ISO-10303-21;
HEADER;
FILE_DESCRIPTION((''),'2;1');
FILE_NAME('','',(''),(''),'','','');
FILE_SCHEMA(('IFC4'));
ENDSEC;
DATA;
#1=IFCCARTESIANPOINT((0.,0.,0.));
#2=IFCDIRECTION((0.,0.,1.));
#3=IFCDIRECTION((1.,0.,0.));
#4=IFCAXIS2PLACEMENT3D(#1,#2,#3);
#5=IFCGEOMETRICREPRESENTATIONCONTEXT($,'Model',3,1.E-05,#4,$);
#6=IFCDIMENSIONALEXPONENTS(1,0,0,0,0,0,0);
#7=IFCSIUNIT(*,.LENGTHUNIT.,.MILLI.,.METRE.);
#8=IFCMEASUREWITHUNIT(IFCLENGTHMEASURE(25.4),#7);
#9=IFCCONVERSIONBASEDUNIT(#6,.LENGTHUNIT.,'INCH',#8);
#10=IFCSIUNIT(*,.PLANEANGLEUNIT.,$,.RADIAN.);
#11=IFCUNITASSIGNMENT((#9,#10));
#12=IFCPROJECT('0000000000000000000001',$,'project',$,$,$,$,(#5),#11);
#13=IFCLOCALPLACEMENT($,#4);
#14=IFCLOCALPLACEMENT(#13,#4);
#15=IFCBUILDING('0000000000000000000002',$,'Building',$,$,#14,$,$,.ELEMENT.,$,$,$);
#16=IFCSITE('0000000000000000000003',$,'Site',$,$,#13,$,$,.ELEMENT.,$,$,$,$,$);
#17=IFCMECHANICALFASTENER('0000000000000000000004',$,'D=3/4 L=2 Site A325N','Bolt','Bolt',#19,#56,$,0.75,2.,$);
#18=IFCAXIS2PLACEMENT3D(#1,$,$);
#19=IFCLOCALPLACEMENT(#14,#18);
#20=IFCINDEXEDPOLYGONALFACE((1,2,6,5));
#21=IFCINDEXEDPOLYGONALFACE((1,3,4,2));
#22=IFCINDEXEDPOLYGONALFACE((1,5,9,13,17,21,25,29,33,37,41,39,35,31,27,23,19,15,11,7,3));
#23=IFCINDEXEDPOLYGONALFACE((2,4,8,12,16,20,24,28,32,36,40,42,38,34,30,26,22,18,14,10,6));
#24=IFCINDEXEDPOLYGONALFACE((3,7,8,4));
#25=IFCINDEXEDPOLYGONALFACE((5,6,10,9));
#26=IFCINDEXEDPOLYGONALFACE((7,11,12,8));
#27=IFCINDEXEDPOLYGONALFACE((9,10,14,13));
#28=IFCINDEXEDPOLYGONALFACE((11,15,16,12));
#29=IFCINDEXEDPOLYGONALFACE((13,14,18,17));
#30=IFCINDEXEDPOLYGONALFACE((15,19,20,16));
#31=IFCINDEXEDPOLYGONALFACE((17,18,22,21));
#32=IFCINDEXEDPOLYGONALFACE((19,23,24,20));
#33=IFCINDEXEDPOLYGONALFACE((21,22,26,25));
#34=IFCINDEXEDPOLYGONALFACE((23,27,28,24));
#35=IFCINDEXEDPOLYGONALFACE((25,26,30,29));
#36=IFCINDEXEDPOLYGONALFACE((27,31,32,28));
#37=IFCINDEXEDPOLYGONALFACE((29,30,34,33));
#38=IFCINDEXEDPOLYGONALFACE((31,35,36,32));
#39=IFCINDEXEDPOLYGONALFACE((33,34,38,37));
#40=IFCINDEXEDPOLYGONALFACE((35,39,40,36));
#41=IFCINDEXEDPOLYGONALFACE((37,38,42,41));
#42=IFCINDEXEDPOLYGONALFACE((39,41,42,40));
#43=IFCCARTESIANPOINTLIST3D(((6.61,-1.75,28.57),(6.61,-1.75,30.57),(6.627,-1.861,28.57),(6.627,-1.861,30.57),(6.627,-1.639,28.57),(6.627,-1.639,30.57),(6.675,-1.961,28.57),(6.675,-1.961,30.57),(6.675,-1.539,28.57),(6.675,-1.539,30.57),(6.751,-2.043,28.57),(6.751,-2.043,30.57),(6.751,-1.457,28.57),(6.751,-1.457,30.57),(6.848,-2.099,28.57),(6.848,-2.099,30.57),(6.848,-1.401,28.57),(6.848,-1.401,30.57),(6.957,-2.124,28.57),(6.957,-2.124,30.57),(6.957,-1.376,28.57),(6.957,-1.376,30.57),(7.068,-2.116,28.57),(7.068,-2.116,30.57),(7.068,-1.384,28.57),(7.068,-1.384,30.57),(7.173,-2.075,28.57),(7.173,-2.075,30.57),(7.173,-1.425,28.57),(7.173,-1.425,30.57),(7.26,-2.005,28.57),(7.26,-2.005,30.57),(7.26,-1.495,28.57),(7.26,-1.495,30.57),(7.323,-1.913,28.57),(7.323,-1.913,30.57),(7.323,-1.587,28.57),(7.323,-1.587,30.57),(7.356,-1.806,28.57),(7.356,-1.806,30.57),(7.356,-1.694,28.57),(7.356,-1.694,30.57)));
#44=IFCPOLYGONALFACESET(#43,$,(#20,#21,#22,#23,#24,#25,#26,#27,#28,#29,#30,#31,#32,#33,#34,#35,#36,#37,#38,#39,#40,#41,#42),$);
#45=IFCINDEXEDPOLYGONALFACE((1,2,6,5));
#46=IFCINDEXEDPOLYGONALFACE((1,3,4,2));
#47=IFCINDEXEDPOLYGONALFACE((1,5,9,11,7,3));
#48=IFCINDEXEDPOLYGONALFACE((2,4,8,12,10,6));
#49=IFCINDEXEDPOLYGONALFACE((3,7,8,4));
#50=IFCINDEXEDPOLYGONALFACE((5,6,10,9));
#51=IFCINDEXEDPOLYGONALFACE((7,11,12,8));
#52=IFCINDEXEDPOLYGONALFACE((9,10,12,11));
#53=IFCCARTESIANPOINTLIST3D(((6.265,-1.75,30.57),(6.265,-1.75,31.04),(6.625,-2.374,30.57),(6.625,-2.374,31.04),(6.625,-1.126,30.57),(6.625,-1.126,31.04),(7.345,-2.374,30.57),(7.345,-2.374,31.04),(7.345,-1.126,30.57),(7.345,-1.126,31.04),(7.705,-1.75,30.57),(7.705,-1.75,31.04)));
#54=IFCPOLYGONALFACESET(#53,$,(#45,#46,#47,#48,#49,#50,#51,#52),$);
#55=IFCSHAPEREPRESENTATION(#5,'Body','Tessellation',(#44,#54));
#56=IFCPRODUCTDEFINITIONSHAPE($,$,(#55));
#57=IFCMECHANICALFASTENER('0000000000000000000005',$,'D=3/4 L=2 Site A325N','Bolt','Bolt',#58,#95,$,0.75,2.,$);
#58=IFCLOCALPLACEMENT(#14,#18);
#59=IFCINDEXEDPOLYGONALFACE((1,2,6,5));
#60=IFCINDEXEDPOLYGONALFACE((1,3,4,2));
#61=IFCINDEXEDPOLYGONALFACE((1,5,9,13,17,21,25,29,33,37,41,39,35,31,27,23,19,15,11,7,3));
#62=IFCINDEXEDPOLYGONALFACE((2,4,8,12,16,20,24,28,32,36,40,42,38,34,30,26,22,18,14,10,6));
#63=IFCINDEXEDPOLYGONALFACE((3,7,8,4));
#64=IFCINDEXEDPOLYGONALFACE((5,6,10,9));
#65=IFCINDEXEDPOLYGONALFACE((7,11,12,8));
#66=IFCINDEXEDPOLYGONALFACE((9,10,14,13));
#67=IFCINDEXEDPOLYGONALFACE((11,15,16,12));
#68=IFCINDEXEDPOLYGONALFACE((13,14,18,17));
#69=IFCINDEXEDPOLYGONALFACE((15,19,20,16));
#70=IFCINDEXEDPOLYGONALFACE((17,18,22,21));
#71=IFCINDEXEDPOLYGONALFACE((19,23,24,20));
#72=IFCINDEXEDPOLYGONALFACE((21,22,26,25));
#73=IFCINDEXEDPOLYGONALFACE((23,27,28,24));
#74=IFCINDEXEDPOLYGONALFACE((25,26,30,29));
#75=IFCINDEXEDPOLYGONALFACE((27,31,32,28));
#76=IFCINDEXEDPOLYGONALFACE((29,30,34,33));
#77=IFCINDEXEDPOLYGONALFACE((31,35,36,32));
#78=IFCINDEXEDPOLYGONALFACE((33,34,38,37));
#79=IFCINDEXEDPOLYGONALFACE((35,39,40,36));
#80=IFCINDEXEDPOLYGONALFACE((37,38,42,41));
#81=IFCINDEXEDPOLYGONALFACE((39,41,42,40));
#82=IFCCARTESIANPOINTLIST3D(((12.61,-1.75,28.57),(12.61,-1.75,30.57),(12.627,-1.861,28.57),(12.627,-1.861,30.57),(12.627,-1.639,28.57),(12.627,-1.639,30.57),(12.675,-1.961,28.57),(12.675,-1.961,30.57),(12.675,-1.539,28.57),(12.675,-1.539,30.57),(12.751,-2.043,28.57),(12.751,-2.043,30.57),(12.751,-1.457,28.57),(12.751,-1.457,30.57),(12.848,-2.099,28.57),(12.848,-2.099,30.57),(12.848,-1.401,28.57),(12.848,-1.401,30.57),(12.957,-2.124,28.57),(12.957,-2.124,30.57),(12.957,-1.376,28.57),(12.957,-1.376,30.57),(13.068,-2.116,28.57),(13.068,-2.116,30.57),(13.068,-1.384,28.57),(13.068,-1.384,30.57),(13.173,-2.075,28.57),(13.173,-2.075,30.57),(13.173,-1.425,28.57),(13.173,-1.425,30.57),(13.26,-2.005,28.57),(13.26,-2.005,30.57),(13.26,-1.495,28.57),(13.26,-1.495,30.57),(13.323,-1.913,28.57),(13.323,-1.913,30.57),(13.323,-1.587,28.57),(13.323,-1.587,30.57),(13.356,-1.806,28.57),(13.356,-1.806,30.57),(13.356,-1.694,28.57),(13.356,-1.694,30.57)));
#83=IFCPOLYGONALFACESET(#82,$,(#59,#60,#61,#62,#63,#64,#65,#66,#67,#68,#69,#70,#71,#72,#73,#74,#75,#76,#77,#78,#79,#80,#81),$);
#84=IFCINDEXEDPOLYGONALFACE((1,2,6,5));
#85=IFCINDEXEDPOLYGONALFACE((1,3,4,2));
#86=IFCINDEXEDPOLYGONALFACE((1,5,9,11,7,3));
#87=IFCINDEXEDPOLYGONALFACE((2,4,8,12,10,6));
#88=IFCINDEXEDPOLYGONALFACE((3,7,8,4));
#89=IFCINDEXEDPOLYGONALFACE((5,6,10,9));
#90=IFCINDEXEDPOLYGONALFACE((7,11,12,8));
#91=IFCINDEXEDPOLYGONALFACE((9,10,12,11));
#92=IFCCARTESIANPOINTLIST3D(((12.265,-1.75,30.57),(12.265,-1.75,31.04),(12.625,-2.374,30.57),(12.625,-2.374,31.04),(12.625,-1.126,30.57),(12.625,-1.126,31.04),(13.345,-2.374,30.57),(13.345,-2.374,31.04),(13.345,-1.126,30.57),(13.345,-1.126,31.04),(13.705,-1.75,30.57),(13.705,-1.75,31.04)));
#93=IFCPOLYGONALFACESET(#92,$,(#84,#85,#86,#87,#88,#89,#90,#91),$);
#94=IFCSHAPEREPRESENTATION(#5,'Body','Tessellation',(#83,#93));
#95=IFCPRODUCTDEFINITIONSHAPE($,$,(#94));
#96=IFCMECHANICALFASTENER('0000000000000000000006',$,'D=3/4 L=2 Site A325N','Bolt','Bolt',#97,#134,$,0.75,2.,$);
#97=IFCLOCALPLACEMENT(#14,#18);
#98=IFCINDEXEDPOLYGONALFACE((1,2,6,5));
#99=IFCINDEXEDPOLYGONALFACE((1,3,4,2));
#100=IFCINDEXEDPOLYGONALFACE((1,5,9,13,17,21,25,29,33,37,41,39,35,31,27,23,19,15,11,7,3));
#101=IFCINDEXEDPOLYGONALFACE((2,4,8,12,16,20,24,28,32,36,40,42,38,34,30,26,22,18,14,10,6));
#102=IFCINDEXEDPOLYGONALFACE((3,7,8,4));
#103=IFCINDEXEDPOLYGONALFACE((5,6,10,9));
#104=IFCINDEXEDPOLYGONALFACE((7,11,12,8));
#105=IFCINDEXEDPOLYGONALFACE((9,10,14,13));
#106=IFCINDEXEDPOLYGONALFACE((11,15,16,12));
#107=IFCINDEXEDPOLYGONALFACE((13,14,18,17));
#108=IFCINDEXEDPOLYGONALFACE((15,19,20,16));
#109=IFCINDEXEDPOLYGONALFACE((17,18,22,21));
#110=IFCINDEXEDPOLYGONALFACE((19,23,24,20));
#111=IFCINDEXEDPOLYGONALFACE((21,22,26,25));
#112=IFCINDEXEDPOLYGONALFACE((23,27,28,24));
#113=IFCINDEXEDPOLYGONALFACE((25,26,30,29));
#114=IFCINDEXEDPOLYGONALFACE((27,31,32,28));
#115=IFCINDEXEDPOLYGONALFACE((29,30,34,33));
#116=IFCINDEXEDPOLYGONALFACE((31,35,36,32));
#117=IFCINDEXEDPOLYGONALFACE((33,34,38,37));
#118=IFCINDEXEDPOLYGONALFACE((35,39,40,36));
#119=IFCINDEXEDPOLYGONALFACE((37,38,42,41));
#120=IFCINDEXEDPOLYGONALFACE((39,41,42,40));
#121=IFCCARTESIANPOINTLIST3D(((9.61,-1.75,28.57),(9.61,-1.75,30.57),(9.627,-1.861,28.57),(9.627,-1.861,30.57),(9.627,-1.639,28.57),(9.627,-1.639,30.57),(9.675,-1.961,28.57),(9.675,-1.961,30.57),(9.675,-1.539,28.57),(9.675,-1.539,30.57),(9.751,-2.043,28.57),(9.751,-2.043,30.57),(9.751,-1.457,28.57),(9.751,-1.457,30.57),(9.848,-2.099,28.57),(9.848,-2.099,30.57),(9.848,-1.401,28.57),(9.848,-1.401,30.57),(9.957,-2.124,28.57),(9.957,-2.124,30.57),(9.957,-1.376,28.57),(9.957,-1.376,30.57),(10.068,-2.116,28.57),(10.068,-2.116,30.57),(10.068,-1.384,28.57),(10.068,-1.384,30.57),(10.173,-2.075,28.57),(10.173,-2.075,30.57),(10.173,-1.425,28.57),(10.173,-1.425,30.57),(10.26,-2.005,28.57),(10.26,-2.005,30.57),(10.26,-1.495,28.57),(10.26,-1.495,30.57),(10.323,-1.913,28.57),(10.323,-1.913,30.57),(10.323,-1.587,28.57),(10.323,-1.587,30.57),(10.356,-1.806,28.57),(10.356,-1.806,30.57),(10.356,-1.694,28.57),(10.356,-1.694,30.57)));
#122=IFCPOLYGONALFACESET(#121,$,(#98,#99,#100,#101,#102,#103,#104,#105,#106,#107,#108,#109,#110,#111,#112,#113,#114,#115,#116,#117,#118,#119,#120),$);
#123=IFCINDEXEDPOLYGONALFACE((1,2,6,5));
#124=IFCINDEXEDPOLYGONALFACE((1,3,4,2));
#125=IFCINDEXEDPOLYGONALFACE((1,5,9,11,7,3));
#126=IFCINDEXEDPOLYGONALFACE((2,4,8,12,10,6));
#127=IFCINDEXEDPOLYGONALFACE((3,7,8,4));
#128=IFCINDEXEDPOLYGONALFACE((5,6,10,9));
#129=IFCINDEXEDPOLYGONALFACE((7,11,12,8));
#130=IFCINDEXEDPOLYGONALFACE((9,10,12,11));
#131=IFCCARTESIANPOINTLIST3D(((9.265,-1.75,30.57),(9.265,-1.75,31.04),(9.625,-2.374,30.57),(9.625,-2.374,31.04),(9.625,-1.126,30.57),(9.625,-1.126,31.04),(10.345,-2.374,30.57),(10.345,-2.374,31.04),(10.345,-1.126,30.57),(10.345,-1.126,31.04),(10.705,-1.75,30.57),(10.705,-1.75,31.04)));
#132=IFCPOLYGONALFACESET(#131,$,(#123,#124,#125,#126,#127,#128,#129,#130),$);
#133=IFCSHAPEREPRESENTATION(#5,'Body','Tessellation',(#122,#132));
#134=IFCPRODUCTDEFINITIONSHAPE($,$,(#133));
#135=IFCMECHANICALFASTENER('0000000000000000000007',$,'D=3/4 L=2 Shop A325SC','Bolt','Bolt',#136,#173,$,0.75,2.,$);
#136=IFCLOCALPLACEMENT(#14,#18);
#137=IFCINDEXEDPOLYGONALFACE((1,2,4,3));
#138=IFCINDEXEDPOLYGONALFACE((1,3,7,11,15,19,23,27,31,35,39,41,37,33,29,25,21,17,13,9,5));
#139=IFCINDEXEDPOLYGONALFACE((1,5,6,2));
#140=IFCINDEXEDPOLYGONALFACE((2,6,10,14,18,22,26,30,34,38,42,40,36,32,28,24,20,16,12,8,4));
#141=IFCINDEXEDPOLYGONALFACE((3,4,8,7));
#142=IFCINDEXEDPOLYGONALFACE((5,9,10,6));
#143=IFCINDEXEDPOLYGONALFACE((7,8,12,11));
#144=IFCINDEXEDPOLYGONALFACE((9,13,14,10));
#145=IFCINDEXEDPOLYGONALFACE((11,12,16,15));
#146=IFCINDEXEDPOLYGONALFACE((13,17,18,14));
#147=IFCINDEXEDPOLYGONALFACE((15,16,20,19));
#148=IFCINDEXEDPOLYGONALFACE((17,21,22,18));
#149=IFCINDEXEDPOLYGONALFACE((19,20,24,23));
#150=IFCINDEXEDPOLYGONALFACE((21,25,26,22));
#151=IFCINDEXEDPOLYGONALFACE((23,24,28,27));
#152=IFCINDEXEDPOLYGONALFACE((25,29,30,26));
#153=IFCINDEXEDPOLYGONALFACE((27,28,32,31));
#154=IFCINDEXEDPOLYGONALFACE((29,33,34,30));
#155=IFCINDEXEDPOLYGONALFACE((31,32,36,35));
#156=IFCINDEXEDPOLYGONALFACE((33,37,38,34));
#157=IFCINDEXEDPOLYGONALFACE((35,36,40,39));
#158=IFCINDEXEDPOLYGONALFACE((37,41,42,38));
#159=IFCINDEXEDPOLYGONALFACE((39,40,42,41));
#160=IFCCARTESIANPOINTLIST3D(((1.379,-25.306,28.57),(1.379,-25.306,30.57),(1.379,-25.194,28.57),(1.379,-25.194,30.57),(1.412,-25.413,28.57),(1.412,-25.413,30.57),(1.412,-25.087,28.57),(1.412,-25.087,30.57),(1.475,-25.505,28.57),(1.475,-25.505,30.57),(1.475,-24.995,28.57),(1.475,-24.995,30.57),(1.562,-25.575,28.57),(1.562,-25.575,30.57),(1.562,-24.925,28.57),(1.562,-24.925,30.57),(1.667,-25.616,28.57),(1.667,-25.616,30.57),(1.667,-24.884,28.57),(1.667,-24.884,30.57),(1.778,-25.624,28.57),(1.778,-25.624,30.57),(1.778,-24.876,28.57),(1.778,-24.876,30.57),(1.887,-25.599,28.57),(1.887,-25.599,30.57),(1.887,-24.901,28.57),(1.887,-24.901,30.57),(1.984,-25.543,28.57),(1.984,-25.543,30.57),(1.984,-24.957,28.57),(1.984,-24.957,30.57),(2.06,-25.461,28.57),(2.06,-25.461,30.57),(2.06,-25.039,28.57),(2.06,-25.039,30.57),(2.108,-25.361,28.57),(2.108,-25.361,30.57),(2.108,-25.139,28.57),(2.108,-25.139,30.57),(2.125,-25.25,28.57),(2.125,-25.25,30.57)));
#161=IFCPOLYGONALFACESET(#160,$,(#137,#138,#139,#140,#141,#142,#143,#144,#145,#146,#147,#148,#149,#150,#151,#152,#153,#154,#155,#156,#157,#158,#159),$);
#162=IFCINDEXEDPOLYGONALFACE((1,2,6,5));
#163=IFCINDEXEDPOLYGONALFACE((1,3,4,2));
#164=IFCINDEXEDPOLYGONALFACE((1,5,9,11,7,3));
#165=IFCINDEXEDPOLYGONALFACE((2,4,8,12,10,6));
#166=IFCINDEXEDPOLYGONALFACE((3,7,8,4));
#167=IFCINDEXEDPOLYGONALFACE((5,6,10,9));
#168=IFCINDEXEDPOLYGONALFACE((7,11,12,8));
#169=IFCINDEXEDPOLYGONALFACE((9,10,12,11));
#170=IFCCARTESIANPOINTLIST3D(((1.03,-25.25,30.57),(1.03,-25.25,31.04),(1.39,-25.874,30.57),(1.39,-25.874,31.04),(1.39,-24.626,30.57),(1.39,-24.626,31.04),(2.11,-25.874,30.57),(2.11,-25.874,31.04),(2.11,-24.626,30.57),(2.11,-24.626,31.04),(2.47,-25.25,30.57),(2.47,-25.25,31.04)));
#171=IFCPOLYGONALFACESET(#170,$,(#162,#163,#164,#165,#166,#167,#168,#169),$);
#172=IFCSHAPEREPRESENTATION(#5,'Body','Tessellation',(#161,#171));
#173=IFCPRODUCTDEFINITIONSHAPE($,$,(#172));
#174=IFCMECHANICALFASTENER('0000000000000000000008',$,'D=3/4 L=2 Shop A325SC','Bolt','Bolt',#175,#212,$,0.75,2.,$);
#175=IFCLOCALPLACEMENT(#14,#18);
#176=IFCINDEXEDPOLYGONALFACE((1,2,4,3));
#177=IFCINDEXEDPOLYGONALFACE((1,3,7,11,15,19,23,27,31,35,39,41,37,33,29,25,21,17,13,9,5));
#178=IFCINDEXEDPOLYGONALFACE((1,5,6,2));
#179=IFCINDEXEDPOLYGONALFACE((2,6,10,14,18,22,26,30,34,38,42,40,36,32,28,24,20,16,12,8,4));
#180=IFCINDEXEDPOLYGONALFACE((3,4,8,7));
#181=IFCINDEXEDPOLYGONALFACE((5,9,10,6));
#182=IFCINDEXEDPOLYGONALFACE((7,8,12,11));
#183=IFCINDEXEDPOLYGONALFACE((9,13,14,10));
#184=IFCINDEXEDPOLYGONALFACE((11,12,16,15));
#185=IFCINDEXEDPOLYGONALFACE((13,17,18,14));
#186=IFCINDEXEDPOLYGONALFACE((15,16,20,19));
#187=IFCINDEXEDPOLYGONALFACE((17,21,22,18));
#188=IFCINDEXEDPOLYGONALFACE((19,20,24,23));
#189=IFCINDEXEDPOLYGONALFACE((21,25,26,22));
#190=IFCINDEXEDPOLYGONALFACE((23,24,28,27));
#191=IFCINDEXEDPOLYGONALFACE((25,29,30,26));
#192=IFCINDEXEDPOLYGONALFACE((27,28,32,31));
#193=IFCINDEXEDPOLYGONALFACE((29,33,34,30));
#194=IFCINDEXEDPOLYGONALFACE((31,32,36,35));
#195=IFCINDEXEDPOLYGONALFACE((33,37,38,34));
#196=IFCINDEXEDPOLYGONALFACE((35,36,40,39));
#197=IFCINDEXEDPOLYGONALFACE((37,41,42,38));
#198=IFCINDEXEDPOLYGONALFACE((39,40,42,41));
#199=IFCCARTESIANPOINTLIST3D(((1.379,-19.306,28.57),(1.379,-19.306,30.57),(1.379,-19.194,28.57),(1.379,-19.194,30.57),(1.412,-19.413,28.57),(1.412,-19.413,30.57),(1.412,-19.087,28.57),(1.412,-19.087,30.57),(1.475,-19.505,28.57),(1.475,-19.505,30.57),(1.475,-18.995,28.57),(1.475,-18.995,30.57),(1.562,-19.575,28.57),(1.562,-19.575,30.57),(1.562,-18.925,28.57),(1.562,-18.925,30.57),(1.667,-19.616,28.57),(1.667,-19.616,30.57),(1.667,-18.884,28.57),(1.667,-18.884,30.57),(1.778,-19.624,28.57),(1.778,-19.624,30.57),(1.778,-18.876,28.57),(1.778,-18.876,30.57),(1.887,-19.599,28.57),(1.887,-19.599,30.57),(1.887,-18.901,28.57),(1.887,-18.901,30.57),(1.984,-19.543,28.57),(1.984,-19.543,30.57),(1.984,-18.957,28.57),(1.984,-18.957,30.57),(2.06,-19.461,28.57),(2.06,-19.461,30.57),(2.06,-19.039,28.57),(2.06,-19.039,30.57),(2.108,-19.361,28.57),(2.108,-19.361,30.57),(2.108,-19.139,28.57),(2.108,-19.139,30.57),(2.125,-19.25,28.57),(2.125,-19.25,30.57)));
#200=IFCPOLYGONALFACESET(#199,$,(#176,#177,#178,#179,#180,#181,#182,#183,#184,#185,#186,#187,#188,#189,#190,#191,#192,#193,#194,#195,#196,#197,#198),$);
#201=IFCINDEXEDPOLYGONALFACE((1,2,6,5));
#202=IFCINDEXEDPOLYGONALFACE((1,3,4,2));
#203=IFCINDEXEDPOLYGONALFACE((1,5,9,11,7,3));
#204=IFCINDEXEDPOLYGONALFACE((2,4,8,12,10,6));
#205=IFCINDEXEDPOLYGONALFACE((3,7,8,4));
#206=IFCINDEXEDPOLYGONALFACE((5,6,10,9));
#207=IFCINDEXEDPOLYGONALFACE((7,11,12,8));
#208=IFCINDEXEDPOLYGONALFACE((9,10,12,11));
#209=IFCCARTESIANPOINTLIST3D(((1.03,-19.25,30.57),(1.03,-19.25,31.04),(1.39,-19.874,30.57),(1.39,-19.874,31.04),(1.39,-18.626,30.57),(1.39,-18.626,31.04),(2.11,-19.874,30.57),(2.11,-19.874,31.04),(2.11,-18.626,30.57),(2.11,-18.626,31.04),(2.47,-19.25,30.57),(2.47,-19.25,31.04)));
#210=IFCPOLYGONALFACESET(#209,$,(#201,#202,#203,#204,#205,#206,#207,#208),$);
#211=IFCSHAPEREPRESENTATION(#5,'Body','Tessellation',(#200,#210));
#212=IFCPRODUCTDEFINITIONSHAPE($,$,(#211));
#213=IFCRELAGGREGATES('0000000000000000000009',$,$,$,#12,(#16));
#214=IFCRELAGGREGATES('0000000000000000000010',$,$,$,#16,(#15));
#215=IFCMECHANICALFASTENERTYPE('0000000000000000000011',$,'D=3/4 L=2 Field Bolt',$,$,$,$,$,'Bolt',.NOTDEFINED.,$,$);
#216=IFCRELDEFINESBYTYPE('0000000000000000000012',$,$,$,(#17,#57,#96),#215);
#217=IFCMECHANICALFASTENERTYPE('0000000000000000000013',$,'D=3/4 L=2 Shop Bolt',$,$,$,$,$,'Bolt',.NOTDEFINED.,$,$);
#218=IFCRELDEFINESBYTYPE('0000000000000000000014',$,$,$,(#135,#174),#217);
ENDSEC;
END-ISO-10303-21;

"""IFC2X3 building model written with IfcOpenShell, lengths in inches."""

from ifc_helpers import new_model, entity, si_unit, converted_unit, frame, origin_with_axes, origin_2d_with_axis, place, context, project, spatial, polyline, circle, outline, extrude, source, transform, mapped, type_object, type_shapes, element, save


model = new_model("IFC2X3")

# Units and contexts
model_context = context("Model", 3, precision=1e-05, world=origin_with_axes())
ifc_project = project(units=[converted_unit("LENGTHUNIT", "INCH", entity("IfcLengthMeasure", 25.4), si_unit("LENGTHUNIT", "METRE", prefix="MILLI"), dimensions=[1, 0, 0, 0, 0, 0, 0]), si_unit("PLANEANGLEUNIT", "RADIAN")], contexts=[model_context])

# Site, building
site_placement = place(None, origin_with_axes())
site = spatial("IfcSite", under=ifc_project, at=site_placement, Name="Site", CompositionType="ELEMENT")
building_placement = place(site_placement, origin_with_axes())
building = spatial("IfcBuilding", under=site, at=building_placement, Name="Building", CompositionType="ELEMENT")

# Shared definitions
assembly_1_placement = place(building_placement, frame((0.0, 0.0, 46.0), z_axis=(0.0, 0.0, 1.0), x_axis=(0.0, -1.0, 0.0)))

# Mechanical fasteners
mechanical_fastener_type_1 = type_object("IfcMechanicalFastenerType", Name="D=3/4 L=2 Field Bolt", ElementType="Bolt")
shared_shape_1 = source(origin_with_axes(), model_context, "Body", "SweptSolid", [
    extrude(circle(Radius=0.375, at=origin_2d_with_axis()), frame((0.0, 0.0, 0.0), z_axis=(1.0, 0.0, 0.0), x_axis=(0.0, 1.0, 0.0)), (0.0, 0.0, 1.0), 2.0),
    extrude(outline(polyline([(-0.72, 0.0), (-0.36, 0.624), (0.36, 0.624), (0.72, 0.0), (0.36, -0.624), (-0.36, -0.624), (-0.72, 0.0)])), frame((0.0, 0.0, 0.0), z_axis=(1.0, 0.0, 0.0), x_axis=(0.0, 1.0, 0.0)), (0.0, 0.0, -1.0), 0.47),
])
type_shapes(mechanical_fastener_type_1, [shared_shape_1])
placement_1 = place(building_placement, frame((0.0, 0.0, 46.0), z_axis=(0.0, 0.0, 1.0), x_axis=(1.0, 0.0, 0.0)))
placement_2 = place(placement_1, frame((6.985, 1.75, -15.43), z_axis=(0.0, 1.0, 0.0), x_axis=(0.0, 0.0, -1.0)))
for number, where, z_axis, x_axis, name in (
    (1, (0.0, 0.0, -3.5), (0.0, 0.0, 1.0), (1.0, 0.0, 0.0), "D=3/4 L=2 Site A325N"),
    (2, (0.0, -6.0, -3.5), (0.0, 0.0, 1.0), (1.0, 0.0, 0.0), "D=3/4 L=2 Site A325N"),
    (3, (0.0, -3.0, -3.5), (0.0, 0.0, 1.0), (1.0, 0.0, 0.0), "D=3/4 L=2 Site A325N"),
):
    element("IfcMechanicalFastener", number, at=place(placement_2, frame(where, z_axis=z_axis, x_axis=x_axis)), type_object=mechanical_fastener_type_1, Name=name, Description="Bolt", ObjectType="Bolt", NominalDiameter=0.75, NominalLength=2.0, context=model_context, shape_type="MappedRepresentation", body=[
        mapped(shared_shape_1, transform((0.0, 0.0, 0.0), scale=1.0)),
    ])
mechanical_fastener_type_2 = type_object("IfcMechanicalFastenerType", Name="D=3/4 L=2 Shop Bolt", ElementType="Bolt")
shared_shape_2 = source(origin_with_axes(), model_context, "Body", "SweptSolid", [
    extrude(circle(Radius=0.375, at=origin_2d_with_axis()), frame((0.0, 0.0, 0.0), z_axis=(1.0, 0.0, 0.0), x_axis=(0.0, 1.0, 0.0)), (0.0, 0.0, 1.0), 2.0),
    extrude(outline(polyline([(-0.72, 0.0), (-0.36, 0.624), (0.36, 0.624), (0.72, 0.0), (0.36, -0.624), (-0.36, -0.624), (-0.72, 0.0)])), frame((0.0, 0.0, 0.0), z_axis=(1.0, 0.0, 0.0), x_axis=(0.0, 1.0, 0.0)), (0.0, 0.0, -1.0), 0.47),
])
type_shapes(mechanical_fastener_type_2, [shared_shape_2])
placement_3 = place(assembly_1_placement, frame((25.25, -1.75, -15.43), z_axis=(1.0, 0.0, 0.0), x_axis=(0.0, 0.0, -1.0)))
for number, where, z_axis, x_axis, name in (
    (4, (0.0, 3.5, 0.0), (0.0, 0.0, 1.0), (1.0, 0.0, 0.0), "D=3/4 L=2 Shop A325SC"),
    (5, (0.0, 3.5, -6.0), (0.0, 0.0, 1.0), (1.0, 0.0, 0.0), "D=3/4 L=2 Shop A325SC"),
):
    element("IfcMechanicalFastener", number, at=place(placement_3, frame(where, z_axis=z_axis, x_axis=x_axis)), type_object=mechanical_fastener_type_2, Name=name, Description="Bolt", ObjectType="Bolt", NominalDiameter=0.75, NominalLength=2.0, context=model_context, shape_type="MappedRepresentation", body=[
        mapped(shared_shape_2, transform((0.0, 0.0, 0.0), scale=1.0)),
    ])

save(model, "model.ifc")
